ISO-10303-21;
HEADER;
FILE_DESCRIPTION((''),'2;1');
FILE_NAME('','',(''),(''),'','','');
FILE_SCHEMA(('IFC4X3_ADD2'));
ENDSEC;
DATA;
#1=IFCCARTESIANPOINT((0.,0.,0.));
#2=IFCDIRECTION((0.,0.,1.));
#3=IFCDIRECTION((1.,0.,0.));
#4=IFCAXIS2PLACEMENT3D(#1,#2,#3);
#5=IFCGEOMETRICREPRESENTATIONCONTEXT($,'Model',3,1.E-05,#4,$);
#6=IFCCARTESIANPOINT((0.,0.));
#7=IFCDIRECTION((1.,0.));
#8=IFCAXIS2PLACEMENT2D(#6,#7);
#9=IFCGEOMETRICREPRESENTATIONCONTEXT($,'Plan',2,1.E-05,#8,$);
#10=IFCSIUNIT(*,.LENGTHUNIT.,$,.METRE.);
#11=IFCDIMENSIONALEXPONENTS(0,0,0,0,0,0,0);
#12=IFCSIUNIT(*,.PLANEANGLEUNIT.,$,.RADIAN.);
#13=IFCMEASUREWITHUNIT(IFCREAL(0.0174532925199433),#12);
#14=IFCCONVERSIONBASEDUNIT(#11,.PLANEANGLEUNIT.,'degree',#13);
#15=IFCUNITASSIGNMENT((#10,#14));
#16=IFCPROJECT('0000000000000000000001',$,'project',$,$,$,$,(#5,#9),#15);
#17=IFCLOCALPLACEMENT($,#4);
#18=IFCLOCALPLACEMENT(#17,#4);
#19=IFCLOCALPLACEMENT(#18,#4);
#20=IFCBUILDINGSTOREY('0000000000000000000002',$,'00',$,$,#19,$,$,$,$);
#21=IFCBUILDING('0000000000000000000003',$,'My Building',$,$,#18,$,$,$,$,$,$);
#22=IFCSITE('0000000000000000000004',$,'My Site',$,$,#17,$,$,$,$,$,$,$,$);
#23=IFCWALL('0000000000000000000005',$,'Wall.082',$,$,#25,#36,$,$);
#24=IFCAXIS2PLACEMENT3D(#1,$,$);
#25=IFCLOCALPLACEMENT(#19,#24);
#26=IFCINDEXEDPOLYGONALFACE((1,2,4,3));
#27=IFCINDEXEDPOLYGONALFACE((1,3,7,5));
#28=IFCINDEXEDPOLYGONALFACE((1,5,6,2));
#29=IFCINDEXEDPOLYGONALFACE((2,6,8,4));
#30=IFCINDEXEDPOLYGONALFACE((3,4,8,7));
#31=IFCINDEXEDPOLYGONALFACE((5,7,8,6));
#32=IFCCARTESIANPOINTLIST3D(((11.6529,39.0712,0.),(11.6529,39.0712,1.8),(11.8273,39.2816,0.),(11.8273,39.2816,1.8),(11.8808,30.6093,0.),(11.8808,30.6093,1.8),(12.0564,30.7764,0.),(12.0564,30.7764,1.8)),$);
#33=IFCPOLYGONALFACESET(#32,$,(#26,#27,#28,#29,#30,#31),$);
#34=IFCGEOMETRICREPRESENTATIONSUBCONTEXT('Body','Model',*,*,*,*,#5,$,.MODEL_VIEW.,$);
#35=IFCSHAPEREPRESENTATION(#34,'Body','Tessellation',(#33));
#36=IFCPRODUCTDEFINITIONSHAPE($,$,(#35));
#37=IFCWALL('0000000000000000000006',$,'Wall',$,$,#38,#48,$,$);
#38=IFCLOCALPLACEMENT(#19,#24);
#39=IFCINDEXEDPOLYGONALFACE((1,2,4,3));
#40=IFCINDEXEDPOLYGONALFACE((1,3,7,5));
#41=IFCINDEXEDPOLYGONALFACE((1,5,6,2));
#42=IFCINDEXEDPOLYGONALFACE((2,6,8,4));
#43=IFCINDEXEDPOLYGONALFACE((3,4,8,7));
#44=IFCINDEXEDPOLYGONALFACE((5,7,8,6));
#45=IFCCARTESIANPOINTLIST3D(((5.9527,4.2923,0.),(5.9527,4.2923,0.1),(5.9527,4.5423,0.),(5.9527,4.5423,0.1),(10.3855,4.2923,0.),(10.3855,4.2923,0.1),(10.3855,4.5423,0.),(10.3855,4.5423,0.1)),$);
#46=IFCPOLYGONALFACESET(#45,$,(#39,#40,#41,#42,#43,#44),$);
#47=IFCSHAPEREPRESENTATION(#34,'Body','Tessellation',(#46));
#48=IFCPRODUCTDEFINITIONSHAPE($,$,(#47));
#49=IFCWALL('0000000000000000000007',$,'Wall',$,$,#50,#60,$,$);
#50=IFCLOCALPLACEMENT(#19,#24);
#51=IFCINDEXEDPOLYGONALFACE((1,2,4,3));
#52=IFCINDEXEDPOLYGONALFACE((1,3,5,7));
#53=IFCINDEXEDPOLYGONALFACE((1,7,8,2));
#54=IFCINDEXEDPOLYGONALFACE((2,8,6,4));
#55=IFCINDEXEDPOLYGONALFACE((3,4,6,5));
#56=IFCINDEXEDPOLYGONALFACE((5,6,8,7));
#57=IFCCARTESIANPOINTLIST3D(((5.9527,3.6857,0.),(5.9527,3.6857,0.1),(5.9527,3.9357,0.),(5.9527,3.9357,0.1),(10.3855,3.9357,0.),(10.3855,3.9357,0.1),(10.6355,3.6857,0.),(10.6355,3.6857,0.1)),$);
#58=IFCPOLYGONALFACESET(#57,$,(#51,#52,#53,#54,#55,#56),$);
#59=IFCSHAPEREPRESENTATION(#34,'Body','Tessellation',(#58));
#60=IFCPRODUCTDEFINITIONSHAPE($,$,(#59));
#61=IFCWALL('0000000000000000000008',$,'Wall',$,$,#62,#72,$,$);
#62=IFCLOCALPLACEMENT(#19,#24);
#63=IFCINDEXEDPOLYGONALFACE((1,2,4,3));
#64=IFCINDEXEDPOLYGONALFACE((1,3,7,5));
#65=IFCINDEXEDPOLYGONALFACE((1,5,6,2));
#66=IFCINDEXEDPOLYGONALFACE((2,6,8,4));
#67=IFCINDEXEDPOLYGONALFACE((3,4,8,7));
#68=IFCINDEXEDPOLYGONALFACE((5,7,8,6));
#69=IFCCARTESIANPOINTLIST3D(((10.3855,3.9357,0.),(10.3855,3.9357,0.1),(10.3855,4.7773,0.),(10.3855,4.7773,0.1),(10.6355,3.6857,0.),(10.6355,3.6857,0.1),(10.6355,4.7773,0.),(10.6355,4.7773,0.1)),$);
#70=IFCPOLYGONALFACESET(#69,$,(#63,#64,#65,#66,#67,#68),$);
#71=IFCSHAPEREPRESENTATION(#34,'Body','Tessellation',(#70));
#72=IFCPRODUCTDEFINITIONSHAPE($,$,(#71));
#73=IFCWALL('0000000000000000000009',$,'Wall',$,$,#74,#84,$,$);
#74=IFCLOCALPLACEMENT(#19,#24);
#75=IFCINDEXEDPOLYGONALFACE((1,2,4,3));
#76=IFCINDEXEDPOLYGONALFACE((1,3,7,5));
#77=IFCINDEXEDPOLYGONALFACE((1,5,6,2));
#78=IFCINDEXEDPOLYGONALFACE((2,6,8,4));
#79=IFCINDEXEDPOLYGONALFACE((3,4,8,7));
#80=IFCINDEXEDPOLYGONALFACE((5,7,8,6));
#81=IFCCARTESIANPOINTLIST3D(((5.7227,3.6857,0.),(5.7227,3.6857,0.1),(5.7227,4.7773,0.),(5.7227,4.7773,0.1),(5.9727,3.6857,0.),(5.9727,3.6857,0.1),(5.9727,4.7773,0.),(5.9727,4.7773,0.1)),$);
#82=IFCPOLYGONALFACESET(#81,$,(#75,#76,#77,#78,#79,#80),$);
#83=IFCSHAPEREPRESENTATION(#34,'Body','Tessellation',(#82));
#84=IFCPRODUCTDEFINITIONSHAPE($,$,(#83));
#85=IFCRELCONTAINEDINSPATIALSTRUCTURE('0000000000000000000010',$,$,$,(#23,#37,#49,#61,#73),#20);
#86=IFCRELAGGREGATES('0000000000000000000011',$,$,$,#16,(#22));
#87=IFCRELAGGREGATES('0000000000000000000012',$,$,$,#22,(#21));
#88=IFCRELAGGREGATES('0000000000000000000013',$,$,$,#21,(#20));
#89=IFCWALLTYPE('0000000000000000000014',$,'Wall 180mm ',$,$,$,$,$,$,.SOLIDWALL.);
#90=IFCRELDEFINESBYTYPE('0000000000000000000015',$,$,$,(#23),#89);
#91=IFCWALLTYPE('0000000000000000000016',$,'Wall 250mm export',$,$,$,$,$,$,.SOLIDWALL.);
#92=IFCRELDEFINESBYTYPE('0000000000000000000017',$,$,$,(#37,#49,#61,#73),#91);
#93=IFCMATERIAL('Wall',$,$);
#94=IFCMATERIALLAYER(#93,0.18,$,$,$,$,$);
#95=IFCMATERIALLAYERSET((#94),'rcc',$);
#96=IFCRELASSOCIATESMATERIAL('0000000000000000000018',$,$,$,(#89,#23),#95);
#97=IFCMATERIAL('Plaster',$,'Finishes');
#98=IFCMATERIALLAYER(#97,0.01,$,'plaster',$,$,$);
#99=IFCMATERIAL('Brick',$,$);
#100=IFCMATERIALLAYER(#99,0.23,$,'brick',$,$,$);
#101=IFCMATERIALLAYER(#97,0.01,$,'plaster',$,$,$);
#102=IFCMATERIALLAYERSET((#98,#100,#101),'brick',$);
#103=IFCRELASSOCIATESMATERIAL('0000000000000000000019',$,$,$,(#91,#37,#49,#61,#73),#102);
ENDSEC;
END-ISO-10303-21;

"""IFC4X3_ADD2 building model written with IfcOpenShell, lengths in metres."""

from ifc_helpers import new_model, entity, si_unit, converted_unit, frame, origin_with_axes, origin_2d_with_axis, place, context, subcontext, project, spatial, line, indexed_curve, outline, extrude, material, layer, layer_set, layer_usage, type_object, element, save


model = new_model("IFC4X3_ADD2")

# Units and contexts
model_context = context("Model", 3, precision=1e-05, world=origin_with_axes())
plan_context = context("Plan", 2, precision=1e-05, world=origin_2d_with_axis())
body_context_1 = subcontext(model_context, "Body", "Model", "MODEL_VIEW")
ifc_project = project(units=[si_unit("LENGTHUNIT", "METRE"), converted_unit("PLANEANGLEUNIT", "degree", entity("IfcReal", 0.0174532925199433), si_unit("PLANEANGLEUNIT", "RADIAN"), dimensions=[0, 0, 0, 0, 0, 0, 0])], contexts=[model_context, plan_context])

# Site, building, storey
site_placement = place(None, origin_with_axes())
site = spatial("IfcSite", under=ifc_project, at=site_placement, Name="My Site")
building_placement = place(site_placement, origin_with_axes())
building = spatial("IfcBuilding", under=site, at=building_placement, Name="My Building")
storey_placement = place(building_placement, origin_with_axes())
storey = spatial("IfcBuildingStorey", under=building, at=storey_placement, Name="00")

# Shared definitions
ifc_material_1 = material(Name="Wall")
ifc_layer_1 = layer(ifc_material_1, 0.18)
ifc_layer_set_1 = layer_set([ifc_layer_1], Name="rcc")
wall_type_1 = type_object("IfcWallType", Name="Wall 180mm ", PredefinedType="SOLIDWALL", material=ifc_layer_set_1)

# Walls
ifc_layer_usage_1 = layer_usage(ifc_layer_set_1, "AXIS2", "NEGATIVE", 0.0)
wall_1_placement = place(storey_placement, frame((11.8273, 39.2816, 0.0), z_axis=(0.0, 0.0, 1.0), x_axis=(0.026917, -0.999638, 0.0)))
element("IfcWall", 1, at=wall_1_placement, inside=storey, type_object=wall_type_1, material=ifc_layer_usage_1, Name="Wall.082", context=body_context_1, shape_type="SweptSolid", body=[
    extrude(outline(indexed_curve([(0.2056, -0.18), (0.0, 0.0), (8.5083, 0.0), (8.6705, -0.18)], segments=[line(1, 2, 3, 4, 1)])), origin_with_axes(), (0.0, 0.0, 1.0), 1.8),
])
ifc_material_2 = material(Name="Plaster", Category="Finishes")
ifc_layer_2 = layer(ifc_material_2, 0.01, Name="plaster")
ifc_material_3 = material(Name="Brick")
ifc_layer_3 = layer(ifc_material_3, 0.23, Name="brick")
ifc_layer_4 = layer(ifc_material_2, 0.01, Name="plaster")
ifc_layer_set_2 = layer_set([ifc_layer_2, ifc_layer_3, ifc_layer_4], Name="brick")
ifc_layer_usage_2 = layer_usage(ifc_layer_set_2, "AXIS2", "POSITIVE", 0.0)
wall_type_2 = type_object("IfcWallType", Name="Wall 250mm export", PredefinedType="SOLIDWALL", material=ifc_layer_set_2)
wall_2_placement = place(storey_placement, frame((5.9527, 4.2923, 0.0), z_axis=(0.0, 0.0, 1.0), x_axis=(1.0, 0.0, 0.0)))
element("IfcWall", 2, at=wall_2_placement, inside=storey, type_object=wall_type_2, material=ifc_layer_usage_2, Name="Wall", context=body_context_1, shape_type="SweptSolid", body=[
    extrude(outline(indexed_curve([(0.0, 0.0), (0.0, 0.25), (4.4327, 0.25), (4.4327, 0.0)], segments=[line(1, 2, 3, 4, 1)])), origin_with_axes(), (0.0, 0.0, 1.0), 0.1),
])
ifc_layer_usage_3 = layer_usage(ifc_layer_set_2, "AXIS2", "POSITIVE", 0.0)
wall_3_placement = place(storey_placement, frame((5.9527, 3.6857, 0.0), z_axis=(0.0, 0.0, 1.0), x_axis=(1.0, 0.0, 0.0)))
element("IfcWall", 3, at=wall_3_placement, inside=storey, type_object=wall_type_2, material=ifc_layer_usage_3, Name="Wall", context=body_context_1, shape_type="SweptSolid", body=[
    extrude(outline(indexed_curve([(0.0, 0.0), (0.0, 0.25), (4.4327, 0.25), (4.6827, 0.0)], segments=[line(1, 2, 3, 4, 1)])), origin_with_axes(), (0.0, 0.0, 1.0), 0.1),
])
ifc_layer_usage_4 = layer_usage(ifc_layer_set_2, "AXIS2", "POSITIVE", 0.0)
wall_4_placement = place(storey_placement, frame((10.3855, 4.7773, 0.0), z_axis=(0.0, 0.0, 1.0), x_axis=(-0.000001, -1.0, 0.0)))
element("IfcWall", 4, at=wall_4_placement, inside=storey, type_object=wall_type_2, material=ifc_layer_usage_4, Name="Wall", context=body_context_1, shape_type="SweptSolid", body=[
    extrude(outline(indexed_curve([(0.0, 0.0), (0.0, 0.25), (1.0916, 0.25), (0.8416, 0.0)], segments=[line(1, 2, 3, 4, 1)])), origin_with_axes(), (0.0, 0.0, 1.0), 0.1),
])
ifc_layer_usage_5 = layer_usage(ifc_layer_set_2, "AXIS2", "POSITIVE", 0.0)
wall_5_placement = place(storey_placement, frame((5.7227, 4.7773, 0.0), z_axis=(0.0, 0.0, 1.0), x_axis=(-0.000001, -1.0, 0.0)))
element("IfcWall", 5, at=wall_5_placement, inside=storey, type_object=wall_type_2, material=ifc_layer_usage_5, Name="Wall", context=body_context_1, shape_type="SweptSolid", body=[
    extrude(outline(indexed_curve([(0.0, 0.0), (0.0, 0.25), (1.0916, 0.25), (1.0916, 0.0)], segments=[line(1, 2, 3, 4, 1)])), origin_with_axes(), (0.0, 0.0, 1.0), 0.1),
])

save(model, "model.ifc")
